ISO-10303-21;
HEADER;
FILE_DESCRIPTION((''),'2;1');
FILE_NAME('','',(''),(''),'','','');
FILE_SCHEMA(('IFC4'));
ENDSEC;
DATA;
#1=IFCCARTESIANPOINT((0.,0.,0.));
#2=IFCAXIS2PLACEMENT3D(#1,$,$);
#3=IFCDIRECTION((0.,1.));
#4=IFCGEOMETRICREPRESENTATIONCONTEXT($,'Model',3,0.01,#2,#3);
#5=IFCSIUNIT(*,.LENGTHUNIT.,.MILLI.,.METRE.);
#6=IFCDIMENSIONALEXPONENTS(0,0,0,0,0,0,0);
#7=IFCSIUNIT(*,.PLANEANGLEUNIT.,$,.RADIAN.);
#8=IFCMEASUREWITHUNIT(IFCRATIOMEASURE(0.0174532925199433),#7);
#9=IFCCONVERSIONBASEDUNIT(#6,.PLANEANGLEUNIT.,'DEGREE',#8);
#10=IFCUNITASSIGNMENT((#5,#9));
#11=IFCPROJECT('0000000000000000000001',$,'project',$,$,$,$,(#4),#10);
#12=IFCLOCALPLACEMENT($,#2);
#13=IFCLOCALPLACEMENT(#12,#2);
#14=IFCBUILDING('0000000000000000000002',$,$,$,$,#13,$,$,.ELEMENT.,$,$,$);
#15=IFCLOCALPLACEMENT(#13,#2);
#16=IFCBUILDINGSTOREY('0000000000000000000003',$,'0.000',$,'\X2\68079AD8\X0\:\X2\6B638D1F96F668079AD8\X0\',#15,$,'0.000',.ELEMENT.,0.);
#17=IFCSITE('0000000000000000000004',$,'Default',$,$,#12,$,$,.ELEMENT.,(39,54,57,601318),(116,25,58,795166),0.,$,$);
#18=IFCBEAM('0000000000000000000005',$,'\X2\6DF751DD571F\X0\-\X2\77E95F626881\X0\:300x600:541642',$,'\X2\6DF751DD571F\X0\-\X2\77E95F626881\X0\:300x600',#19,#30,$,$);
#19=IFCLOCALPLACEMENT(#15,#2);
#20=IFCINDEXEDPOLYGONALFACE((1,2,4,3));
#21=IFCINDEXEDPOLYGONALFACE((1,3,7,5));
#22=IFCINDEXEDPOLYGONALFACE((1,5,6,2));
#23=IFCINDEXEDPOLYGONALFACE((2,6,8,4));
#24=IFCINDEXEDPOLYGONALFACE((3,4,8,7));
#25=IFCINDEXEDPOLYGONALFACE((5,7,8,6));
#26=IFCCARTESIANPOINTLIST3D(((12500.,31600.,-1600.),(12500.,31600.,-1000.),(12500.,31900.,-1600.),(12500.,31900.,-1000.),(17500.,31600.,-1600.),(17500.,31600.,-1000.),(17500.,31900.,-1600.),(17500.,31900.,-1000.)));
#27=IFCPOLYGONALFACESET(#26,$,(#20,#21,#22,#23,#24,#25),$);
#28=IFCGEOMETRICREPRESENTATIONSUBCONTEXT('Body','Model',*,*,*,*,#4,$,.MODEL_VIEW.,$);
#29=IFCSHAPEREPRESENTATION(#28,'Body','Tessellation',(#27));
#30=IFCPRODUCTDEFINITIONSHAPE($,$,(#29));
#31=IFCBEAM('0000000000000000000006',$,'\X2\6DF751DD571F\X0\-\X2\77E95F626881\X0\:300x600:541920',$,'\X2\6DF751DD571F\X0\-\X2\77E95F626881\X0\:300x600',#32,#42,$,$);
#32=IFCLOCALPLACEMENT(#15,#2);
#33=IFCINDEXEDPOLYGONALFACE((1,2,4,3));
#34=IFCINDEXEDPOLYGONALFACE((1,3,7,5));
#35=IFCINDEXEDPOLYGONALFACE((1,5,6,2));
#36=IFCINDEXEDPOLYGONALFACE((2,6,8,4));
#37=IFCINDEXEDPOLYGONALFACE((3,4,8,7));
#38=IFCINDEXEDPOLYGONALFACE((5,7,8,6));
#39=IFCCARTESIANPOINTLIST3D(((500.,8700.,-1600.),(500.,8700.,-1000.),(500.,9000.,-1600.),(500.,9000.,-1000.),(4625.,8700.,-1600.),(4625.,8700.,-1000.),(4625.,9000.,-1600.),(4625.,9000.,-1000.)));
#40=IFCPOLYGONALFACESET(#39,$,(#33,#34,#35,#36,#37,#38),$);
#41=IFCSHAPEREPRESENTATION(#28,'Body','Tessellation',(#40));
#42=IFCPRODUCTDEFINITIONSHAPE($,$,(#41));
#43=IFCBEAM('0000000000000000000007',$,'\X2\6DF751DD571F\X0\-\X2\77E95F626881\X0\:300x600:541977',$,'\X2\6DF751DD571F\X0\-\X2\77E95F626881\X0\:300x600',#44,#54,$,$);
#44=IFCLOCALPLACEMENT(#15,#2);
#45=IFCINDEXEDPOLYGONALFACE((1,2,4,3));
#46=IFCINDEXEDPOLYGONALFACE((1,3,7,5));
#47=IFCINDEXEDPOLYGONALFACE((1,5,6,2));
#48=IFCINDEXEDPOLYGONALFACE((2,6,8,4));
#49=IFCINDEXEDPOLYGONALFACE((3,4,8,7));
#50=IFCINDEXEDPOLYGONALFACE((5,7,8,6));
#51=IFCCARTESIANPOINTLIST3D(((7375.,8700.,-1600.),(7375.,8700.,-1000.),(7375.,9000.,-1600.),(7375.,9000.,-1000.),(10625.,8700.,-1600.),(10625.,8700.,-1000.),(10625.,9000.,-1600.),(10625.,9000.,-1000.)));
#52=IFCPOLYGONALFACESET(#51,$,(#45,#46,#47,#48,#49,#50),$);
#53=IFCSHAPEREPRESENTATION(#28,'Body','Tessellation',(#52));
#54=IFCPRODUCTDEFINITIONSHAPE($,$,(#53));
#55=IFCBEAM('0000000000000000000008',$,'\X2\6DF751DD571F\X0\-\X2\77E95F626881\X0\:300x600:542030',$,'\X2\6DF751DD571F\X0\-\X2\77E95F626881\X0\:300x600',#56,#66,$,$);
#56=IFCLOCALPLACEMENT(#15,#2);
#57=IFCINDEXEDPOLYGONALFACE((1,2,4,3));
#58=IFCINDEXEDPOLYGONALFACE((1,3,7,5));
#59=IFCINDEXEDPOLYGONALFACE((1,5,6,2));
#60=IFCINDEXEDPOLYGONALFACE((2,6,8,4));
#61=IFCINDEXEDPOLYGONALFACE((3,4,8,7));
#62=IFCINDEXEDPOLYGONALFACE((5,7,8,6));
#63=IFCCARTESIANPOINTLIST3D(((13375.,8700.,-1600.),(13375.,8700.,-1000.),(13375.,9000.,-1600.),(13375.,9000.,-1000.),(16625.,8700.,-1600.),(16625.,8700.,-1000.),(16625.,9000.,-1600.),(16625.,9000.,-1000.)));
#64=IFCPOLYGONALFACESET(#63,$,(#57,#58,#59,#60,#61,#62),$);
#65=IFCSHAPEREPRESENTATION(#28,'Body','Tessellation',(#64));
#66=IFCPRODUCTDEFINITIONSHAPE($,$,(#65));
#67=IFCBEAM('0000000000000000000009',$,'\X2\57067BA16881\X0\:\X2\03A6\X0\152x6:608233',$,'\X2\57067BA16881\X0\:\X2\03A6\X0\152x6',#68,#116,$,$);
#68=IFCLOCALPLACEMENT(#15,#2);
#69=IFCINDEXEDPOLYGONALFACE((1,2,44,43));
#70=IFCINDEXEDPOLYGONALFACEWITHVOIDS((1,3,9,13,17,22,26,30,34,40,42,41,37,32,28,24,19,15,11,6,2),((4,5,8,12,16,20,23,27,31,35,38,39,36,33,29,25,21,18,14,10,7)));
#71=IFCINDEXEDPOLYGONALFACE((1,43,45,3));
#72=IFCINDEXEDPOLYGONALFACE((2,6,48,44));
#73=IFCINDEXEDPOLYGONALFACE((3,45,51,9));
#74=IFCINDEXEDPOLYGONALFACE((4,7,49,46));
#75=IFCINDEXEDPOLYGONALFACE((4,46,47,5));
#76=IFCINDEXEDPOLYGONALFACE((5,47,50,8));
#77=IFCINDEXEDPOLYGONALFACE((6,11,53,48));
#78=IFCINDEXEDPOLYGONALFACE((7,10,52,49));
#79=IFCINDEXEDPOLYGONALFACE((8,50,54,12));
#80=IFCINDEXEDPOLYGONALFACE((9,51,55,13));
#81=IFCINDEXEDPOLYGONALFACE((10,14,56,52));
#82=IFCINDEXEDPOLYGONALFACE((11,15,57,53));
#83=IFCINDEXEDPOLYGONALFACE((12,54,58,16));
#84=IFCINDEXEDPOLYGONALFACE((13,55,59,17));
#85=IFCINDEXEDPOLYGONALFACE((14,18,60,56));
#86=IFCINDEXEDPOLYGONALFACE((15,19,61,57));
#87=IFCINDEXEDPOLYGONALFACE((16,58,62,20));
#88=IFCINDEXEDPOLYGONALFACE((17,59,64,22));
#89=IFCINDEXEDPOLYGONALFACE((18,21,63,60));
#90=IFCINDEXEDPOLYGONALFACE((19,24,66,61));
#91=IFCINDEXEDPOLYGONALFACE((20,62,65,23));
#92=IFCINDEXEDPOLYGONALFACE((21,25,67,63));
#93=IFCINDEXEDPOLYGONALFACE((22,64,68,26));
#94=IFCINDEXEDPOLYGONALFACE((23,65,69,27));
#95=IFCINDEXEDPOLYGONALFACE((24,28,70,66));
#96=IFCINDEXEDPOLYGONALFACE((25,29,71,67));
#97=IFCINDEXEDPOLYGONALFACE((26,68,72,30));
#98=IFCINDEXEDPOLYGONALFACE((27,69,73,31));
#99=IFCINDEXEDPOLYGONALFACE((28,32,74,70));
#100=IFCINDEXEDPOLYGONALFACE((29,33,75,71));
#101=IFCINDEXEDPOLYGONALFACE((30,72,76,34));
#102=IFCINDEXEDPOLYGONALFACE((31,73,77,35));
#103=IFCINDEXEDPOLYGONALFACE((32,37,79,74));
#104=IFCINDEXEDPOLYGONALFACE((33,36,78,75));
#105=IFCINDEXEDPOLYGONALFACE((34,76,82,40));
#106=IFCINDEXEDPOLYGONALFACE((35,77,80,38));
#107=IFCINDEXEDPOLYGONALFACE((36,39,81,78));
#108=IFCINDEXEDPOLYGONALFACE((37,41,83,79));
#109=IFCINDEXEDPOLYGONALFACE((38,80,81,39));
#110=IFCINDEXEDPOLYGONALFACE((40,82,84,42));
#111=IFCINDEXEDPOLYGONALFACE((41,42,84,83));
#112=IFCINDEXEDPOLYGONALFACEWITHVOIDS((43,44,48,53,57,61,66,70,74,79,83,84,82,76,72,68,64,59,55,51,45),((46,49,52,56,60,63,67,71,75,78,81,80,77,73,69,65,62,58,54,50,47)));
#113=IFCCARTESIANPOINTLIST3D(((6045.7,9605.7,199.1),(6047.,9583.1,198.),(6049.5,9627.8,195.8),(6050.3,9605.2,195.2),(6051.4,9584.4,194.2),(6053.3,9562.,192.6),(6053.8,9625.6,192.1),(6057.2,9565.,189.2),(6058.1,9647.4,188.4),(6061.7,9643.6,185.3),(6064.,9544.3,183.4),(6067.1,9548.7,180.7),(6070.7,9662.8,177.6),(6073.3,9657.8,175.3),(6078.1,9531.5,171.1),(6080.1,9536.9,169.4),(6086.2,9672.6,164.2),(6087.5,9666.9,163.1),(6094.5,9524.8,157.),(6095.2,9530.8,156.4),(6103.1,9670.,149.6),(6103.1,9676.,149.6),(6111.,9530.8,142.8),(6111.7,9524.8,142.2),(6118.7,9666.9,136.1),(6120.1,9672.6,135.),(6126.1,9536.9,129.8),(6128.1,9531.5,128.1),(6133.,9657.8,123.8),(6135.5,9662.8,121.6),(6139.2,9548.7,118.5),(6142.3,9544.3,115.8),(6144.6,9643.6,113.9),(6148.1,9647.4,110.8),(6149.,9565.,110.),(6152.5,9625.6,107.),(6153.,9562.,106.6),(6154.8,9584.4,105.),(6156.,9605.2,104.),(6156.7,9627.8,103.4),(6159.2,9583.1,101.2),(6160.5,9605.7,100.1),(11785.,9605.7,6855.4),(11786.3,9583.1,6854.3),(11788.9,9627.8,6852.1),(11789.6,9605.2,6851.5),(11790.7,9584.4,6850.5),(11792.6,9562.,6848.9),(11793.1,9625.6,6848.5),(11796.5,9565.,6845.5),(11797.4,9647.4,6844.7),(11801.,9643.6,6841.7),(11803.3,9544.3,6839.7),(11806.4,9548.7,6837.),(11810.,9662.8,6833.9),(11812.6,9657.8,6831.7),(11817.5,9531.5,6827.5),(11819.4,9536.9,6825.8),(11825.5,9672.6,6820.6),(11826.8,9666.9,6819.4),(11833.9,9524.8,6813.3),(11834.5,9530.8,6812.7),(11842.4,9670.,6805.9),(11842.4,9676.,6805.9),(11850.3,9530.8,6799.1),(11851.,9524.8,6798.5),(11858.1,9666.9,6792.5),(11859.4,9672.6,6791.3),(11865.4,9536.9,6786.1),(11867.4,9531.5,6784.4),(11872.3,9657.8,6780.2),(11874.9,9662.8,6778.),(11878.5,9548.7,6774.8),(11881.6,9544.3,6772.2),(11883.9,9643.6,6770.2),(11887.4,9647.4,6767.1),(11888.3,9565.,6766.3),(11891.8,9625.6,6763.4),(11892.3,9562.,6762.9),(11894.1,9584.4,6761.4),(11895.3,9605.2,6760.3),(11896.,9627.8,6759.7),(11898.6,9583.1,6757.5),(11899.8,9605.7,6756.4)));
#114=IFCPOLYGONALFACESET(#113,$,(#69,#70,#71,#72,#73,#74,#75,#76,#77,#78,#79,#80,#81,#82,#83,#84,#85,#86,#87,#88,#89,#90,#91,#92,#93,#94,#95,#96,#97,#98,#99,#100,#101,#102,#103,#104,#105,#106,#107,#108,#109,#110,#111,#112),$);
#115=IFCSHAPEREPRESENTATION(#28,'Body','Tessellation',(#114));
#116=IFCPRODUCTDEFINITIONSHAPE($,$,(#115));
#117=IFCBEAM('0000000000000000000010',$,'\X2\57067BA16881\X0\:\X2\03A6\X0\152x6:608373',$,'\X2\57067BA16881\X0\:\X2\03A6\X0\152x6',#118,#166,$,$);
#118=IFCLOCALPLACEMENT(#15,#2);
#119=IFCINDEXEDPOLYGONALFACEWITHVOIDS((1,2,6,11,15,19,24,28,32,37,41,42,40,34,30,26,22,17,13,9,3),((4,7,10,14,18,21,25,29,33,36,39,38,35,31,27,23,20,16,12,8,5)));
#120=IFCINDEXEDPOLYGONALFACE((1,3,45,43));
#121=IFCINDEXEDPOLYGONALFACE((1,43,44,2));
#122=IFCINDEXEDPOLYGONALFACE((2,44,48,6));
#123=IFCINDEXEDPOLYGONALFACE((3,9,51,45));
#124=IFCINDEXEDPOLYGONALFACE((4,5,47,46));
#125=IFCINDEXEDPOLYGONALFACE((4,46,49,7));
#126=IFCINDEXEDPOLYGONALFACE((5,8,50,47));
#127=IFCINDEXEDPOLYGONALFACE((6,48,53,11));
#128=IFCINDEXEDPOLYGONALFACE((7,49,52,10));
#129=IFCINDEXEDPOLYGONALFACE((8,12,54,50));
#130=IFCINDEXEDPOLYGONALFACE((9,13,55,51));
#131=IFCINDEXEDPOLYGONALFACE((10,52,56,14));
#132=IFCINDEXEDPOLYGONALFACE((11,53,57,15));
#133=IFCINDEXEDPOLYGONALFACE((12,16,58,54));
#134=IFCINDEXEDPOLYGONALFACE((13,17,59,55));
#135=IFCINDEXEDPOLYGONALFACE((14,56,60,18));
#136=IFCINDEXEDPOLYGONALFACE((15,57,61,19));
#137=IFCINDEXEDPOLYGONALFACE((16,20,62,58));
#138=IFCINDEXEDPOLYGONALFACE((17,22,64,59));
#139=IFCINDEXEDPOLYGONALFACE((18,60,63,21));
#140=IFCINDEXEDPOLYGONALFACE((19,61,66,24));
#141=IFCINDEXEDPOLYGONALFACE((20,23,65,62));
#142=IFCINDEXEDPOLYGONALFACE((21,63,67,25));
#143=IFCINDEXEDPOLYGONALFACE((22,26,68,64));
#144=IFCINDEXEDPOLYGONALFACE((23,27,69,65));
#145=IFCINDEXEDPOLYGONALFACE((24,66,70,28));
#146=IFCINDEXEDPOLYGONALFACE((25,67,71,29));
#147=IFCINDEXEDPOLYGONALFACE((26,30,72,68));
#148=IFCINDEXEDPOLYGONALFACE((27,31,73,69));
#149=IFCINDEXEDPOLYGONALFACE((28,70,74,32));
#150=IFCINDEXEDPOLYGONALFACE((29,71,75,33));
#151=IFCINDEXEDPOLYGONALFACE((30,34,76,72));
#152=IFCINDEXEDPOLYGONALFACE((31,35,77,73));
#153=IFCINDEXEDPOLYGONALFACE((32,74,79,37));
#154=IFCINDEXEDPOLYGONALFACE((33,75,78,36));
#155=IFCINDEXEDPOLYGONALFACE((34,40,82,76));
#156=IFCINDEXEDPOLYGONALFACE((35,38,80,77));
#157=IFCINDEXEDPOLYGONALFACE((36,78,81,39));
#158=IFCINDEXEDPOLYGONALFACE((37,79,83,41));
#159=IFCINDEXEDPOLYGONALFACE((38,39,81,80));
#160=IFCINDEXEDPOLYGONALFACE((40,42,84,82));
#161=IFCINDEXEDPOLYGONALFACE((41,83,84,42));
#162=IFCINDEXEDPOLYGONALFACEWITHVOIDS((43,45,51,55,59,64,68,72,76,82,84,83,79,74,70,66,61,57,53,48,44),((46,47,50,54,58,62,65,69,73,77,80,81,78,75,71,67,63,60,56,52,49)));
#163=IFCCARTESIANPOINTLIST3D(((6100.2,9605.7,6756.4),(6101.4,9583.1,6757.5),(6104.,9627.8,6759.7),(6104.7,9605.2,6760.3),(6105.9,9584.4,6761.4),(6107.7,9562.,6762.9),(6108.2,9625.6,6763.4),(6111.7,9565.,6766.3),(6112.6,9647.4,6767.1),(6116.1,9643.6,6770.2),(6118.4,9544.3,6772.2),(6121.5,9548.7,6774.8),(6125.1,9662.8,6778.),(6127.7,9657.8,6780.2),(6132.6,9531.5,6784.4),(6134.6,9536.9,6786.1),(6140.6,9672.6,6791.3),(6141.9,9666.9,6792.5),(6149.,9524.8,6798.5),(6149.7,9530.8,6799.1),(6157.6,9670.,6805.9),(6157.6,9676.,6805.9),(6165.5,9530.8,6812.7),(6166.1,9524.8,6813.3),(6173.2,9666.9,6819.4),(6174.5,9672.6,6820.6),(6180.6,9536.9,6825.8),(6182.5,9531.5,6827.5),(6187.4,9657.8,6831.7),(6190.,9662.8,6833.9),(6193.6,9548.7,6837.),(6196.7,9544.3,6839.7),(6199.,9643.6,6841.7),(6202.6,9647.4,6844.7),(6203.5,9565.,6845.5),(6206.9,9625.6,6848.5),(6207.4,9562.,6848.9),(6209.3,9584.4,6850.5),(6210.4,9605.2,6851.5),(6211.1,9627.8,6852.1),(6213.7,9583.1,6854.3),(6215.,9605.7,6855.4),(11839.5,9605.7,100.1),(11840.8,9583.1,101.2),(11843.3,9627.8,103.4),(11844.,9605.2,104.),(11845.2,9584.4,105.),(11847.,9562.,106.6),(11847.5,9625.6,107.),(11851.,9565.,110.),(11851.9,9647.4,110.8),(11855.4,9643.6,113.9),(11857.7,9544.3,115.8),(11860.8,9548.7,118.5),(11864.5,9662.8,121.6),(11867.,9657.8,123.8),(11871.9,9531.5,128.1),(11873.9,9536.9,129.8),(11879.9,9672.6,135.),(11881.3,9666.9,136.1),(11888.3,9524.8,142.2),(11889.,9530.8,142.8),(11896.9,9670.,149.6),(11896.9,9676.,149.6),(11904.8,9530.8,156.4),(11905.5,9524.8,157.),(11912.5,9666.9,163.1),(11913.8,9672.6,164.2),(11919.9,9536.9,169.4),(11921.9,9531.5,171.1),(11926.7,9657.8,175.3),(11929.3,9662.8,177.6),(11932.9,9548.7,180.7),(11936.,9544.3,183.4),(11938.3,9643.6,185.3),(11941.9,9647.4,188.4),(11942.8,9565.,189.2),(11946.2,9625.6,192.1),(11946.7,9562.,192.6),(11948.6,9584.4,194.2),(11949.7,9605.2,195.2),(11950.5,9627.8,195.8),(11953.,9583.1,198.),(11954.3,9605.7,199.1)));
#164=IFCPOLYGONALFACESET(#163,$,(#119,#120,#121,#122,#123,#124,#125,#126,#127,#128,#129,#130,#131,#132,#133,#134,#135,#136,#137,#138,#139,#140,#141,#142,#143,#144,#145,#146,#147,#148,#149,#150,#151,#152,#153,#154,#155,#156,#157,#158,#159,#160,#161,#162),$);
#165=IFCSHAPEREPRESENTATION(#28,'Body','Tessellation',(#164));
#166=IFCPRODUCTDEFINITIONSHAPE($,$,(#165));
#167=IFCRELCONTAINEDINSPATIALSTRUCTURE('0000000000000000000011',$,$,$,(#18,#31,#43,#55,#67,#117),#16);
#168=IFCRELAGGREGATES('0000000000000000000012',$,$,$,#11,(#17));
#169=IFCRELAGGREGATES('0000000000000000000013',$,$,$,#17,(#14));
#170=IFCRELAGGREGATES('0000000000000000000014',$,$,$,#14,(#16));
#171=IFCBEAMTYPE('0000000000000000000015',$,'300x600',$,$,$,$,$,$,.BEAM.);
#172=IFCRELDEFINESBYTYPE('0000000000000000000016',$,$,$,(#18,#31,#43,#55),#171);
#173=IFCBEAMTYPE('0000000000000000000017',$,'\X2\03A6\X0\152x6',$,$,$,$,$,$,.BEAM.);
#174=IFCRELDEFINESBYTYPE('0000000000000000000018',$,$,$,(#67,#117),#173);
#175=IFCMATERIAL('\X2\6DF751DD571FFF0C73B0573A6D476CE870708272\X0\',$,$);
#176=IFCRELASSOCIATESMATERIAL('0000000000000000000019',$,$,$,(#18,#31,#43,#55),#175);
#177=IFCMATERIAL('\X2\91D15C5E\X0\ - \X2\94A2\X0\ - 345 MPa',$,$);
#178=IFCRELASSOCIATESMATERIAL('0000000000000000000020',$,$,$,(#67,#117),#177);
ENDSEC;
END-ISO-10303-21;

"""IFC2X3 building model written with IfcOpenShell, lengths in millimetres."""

from ifc_helpers import new_model, entity, si_unit, converted_unit, direction, frame, frame_2d, origin, place, context, subcontext, project, spatial, rectangle, hollow_circle, extrude, material, type_object, element, save


model = new_model("IFC2X3")

# Units and contexts
model_context = context("Model", 3, precision=0.01, world=origin(), true_north=direction((0.0, 1.0)))
body_context = subcontext(model_context, "Body", "Model", "MODEL_VIEW")
ifc_project = project(units=[si_unit("LENGTHUNIT", "METRE", prefix="MILLI"), converted_unit("PLANEANGLEUNIT", "DEGREE", entity("IfcRatioMeasure", 0.0174532925199433), si_unit("PLANEANGLEUNIT", "RADIAN"), dimensions=[0, 0, 0, 0, 0, 0, 0])], contexts=[model_context])

# Site, building, storey
site_placement = place(None, origin())
site = spatial("IfcSite", under=ifc_project, at=site_placement, Name="Default", CompositionType="ELEMENT", RefLatitude=(39, 54, 57, 601318), RefLongitude=(116, 25, 58, 795166), RefElevation=0.0)
building_placement = place(site_placement, origin())
building = spatial("IfcBuilding", under=site, at=building_placement, CompositionType="ELEMENT")
storey_placement = place(building_placement, origin())
storey = spatial("IfcBuildingStorey", under=building, at=storey_placement, Name="0.000", ObjectType="标高:正负零标高", LongName="0.000", CompositionType="ELEMENT", Elevation=0.0)

# Shared definitions
ifc_material_1 = material(Name="金属 - 钢 - 345 MPa")

# Beams
ifc_material_2 = material(Name="混凝土，现场浇注灰色")
beam_type_1 = type_object("IfcBeamType", Name="300x600", PredefinedType="BEAM")
beam_1_placement = place(storey_placement, frame((12500.0, 31900.0, 0.0)))
element("IfcBeam", 1, at=beam_1_placement, inside=storey, type_object=beam_type_1, material=ifc_material_2, Name="混凝土-矩形梁:300x600:541642", ObjectType="混凝土-矩形梁:300x600", context=body_context, shape_type="SweptSolid", body=[
    extrude(rectangle(XDim=600.0, YDim=300.0, at=frame_2d((0.0, 0.0), x_axis=(1.0, 0.0))), frame((0.0, -150.0, -1300.0), z_axis=(1.0, 0.0, 0.0), x_axis=(0.0, 0.0, -1.0)), (0.0, 0.0, 1.0), 5000.0),
])
beam_2_placement = place(storey_placement, frame((500.0, 9000.0, 0.0)))
element("IfcBeam", 2, at=beam_2_placement, inside=storey, type_object=beam_type_1, material=ifc_material_2, Name="混凝土-矩形梁:300x600:541920", ObjectType="混凝土-矩形梁:300x600", context=body_context, shape_type="SweptSolid", body=[
    extrude(rectangle(XDim=600.0, YDim=300.0, at=frame_2d((0.0, 0.0), x_axis=(1.0, 0.0))), frame((0.0, -150.0, -1300.0), z_axis=(1.0, 0.0, 0.0), x_axis=(0.0, 0.0, -1.0)), (0.0, 0.0, 1.0), 4125.0),
])
for number, where, name in (
    (3, (7375.0, 9000.0, 0.0), "混凝土-矩形梁:300x600:541977"),
    (4, (13375.0, 9000.0, 0.0), "混凝土-矩形梁:300x600:542030"),
):
    element("IfcBeam", number, at=place(storey_placement, frame(where)), inside=storey, type_object=beam_type_1, material=ifc_material_2, Name=name, ObjectType="混凝土-矩形梁:300x600", context=body_context, shape_type="SweptSolid", body=[
        extrude(rectangle(XDim=600.0, YDim=300.0, at=frame_2d((0.0, 0.0), x_axis=(1.0, 0.0))), frame((0.0, -150.0, -1300.0), z_axis=(1.0, 0.0, 0.0), x_axis=(0.0, 0.0, -1.0)), (0.0, 0.0, 1.0), 3250.0),
    ])
beam_type_2 = type_object("IfcBeamType", Name="Φ152x6", PredefinedType="BEAM")
beam_3_placement = place(storey_placement, frame((6138.2, 9600.0, -116.0), z_axis=(0.757348, 0.0, -0.653011), x_axis=(0.653011, 0.0, 0.757348)))
element("IfcBeam", 5, at=beam_3_placement, inside=storey, type_object=beam_type_2, material=ifc_material_1, Name="圆管梁:Φ152x6:608233", ObjectType="圆管梁:Φ152x6", context=body_context, shape_type="SweptSolid", body=[
    extrude(hollow_circle(Radius=76.0, WallThickness=6.0, at=frame_2d((0.0, 0.0), x_axis=(1.0, 0.0))), frame((178.3, 0.0, -200.0), z_axis=(1.0, 0.0, 0.0), x_axis=(0.0, -1.0, 0.0)), (0.0, 0.0, 1.0), 8789.0),
])
beam_4_placement = place(storey_placement, frame((11861.8, 9600.0, -116.0), z_axis=(0.757348, 0.0, 0.653011), x_axis=(-0.653011, 0.0, 0.757348)))
element("IfcBeam", 6, at=beam_4_placement, inside=storey, type_object=beam_type_2, material=ifc_material_1, Name="圆管梁:Φ152x6:608373", ObjectType="圆管梁:Φ152x6", context=body_context, shape_type="SweptSolid", body=[
    extrude(hollow_circle(Radius=76.0, WallThickness=6.0, at=frame_2d((0.0, 0.0), x_axis=(1.0, 0.0))), frame((178.3, 0.0, 200.0), z_axis=(1.0, 0.0, 0.0), x_axis=(0.0, -1.0, 0.0)), (0.0, 0.0, 1.0), 8789.0),
])

save(model, "model.ifc")
